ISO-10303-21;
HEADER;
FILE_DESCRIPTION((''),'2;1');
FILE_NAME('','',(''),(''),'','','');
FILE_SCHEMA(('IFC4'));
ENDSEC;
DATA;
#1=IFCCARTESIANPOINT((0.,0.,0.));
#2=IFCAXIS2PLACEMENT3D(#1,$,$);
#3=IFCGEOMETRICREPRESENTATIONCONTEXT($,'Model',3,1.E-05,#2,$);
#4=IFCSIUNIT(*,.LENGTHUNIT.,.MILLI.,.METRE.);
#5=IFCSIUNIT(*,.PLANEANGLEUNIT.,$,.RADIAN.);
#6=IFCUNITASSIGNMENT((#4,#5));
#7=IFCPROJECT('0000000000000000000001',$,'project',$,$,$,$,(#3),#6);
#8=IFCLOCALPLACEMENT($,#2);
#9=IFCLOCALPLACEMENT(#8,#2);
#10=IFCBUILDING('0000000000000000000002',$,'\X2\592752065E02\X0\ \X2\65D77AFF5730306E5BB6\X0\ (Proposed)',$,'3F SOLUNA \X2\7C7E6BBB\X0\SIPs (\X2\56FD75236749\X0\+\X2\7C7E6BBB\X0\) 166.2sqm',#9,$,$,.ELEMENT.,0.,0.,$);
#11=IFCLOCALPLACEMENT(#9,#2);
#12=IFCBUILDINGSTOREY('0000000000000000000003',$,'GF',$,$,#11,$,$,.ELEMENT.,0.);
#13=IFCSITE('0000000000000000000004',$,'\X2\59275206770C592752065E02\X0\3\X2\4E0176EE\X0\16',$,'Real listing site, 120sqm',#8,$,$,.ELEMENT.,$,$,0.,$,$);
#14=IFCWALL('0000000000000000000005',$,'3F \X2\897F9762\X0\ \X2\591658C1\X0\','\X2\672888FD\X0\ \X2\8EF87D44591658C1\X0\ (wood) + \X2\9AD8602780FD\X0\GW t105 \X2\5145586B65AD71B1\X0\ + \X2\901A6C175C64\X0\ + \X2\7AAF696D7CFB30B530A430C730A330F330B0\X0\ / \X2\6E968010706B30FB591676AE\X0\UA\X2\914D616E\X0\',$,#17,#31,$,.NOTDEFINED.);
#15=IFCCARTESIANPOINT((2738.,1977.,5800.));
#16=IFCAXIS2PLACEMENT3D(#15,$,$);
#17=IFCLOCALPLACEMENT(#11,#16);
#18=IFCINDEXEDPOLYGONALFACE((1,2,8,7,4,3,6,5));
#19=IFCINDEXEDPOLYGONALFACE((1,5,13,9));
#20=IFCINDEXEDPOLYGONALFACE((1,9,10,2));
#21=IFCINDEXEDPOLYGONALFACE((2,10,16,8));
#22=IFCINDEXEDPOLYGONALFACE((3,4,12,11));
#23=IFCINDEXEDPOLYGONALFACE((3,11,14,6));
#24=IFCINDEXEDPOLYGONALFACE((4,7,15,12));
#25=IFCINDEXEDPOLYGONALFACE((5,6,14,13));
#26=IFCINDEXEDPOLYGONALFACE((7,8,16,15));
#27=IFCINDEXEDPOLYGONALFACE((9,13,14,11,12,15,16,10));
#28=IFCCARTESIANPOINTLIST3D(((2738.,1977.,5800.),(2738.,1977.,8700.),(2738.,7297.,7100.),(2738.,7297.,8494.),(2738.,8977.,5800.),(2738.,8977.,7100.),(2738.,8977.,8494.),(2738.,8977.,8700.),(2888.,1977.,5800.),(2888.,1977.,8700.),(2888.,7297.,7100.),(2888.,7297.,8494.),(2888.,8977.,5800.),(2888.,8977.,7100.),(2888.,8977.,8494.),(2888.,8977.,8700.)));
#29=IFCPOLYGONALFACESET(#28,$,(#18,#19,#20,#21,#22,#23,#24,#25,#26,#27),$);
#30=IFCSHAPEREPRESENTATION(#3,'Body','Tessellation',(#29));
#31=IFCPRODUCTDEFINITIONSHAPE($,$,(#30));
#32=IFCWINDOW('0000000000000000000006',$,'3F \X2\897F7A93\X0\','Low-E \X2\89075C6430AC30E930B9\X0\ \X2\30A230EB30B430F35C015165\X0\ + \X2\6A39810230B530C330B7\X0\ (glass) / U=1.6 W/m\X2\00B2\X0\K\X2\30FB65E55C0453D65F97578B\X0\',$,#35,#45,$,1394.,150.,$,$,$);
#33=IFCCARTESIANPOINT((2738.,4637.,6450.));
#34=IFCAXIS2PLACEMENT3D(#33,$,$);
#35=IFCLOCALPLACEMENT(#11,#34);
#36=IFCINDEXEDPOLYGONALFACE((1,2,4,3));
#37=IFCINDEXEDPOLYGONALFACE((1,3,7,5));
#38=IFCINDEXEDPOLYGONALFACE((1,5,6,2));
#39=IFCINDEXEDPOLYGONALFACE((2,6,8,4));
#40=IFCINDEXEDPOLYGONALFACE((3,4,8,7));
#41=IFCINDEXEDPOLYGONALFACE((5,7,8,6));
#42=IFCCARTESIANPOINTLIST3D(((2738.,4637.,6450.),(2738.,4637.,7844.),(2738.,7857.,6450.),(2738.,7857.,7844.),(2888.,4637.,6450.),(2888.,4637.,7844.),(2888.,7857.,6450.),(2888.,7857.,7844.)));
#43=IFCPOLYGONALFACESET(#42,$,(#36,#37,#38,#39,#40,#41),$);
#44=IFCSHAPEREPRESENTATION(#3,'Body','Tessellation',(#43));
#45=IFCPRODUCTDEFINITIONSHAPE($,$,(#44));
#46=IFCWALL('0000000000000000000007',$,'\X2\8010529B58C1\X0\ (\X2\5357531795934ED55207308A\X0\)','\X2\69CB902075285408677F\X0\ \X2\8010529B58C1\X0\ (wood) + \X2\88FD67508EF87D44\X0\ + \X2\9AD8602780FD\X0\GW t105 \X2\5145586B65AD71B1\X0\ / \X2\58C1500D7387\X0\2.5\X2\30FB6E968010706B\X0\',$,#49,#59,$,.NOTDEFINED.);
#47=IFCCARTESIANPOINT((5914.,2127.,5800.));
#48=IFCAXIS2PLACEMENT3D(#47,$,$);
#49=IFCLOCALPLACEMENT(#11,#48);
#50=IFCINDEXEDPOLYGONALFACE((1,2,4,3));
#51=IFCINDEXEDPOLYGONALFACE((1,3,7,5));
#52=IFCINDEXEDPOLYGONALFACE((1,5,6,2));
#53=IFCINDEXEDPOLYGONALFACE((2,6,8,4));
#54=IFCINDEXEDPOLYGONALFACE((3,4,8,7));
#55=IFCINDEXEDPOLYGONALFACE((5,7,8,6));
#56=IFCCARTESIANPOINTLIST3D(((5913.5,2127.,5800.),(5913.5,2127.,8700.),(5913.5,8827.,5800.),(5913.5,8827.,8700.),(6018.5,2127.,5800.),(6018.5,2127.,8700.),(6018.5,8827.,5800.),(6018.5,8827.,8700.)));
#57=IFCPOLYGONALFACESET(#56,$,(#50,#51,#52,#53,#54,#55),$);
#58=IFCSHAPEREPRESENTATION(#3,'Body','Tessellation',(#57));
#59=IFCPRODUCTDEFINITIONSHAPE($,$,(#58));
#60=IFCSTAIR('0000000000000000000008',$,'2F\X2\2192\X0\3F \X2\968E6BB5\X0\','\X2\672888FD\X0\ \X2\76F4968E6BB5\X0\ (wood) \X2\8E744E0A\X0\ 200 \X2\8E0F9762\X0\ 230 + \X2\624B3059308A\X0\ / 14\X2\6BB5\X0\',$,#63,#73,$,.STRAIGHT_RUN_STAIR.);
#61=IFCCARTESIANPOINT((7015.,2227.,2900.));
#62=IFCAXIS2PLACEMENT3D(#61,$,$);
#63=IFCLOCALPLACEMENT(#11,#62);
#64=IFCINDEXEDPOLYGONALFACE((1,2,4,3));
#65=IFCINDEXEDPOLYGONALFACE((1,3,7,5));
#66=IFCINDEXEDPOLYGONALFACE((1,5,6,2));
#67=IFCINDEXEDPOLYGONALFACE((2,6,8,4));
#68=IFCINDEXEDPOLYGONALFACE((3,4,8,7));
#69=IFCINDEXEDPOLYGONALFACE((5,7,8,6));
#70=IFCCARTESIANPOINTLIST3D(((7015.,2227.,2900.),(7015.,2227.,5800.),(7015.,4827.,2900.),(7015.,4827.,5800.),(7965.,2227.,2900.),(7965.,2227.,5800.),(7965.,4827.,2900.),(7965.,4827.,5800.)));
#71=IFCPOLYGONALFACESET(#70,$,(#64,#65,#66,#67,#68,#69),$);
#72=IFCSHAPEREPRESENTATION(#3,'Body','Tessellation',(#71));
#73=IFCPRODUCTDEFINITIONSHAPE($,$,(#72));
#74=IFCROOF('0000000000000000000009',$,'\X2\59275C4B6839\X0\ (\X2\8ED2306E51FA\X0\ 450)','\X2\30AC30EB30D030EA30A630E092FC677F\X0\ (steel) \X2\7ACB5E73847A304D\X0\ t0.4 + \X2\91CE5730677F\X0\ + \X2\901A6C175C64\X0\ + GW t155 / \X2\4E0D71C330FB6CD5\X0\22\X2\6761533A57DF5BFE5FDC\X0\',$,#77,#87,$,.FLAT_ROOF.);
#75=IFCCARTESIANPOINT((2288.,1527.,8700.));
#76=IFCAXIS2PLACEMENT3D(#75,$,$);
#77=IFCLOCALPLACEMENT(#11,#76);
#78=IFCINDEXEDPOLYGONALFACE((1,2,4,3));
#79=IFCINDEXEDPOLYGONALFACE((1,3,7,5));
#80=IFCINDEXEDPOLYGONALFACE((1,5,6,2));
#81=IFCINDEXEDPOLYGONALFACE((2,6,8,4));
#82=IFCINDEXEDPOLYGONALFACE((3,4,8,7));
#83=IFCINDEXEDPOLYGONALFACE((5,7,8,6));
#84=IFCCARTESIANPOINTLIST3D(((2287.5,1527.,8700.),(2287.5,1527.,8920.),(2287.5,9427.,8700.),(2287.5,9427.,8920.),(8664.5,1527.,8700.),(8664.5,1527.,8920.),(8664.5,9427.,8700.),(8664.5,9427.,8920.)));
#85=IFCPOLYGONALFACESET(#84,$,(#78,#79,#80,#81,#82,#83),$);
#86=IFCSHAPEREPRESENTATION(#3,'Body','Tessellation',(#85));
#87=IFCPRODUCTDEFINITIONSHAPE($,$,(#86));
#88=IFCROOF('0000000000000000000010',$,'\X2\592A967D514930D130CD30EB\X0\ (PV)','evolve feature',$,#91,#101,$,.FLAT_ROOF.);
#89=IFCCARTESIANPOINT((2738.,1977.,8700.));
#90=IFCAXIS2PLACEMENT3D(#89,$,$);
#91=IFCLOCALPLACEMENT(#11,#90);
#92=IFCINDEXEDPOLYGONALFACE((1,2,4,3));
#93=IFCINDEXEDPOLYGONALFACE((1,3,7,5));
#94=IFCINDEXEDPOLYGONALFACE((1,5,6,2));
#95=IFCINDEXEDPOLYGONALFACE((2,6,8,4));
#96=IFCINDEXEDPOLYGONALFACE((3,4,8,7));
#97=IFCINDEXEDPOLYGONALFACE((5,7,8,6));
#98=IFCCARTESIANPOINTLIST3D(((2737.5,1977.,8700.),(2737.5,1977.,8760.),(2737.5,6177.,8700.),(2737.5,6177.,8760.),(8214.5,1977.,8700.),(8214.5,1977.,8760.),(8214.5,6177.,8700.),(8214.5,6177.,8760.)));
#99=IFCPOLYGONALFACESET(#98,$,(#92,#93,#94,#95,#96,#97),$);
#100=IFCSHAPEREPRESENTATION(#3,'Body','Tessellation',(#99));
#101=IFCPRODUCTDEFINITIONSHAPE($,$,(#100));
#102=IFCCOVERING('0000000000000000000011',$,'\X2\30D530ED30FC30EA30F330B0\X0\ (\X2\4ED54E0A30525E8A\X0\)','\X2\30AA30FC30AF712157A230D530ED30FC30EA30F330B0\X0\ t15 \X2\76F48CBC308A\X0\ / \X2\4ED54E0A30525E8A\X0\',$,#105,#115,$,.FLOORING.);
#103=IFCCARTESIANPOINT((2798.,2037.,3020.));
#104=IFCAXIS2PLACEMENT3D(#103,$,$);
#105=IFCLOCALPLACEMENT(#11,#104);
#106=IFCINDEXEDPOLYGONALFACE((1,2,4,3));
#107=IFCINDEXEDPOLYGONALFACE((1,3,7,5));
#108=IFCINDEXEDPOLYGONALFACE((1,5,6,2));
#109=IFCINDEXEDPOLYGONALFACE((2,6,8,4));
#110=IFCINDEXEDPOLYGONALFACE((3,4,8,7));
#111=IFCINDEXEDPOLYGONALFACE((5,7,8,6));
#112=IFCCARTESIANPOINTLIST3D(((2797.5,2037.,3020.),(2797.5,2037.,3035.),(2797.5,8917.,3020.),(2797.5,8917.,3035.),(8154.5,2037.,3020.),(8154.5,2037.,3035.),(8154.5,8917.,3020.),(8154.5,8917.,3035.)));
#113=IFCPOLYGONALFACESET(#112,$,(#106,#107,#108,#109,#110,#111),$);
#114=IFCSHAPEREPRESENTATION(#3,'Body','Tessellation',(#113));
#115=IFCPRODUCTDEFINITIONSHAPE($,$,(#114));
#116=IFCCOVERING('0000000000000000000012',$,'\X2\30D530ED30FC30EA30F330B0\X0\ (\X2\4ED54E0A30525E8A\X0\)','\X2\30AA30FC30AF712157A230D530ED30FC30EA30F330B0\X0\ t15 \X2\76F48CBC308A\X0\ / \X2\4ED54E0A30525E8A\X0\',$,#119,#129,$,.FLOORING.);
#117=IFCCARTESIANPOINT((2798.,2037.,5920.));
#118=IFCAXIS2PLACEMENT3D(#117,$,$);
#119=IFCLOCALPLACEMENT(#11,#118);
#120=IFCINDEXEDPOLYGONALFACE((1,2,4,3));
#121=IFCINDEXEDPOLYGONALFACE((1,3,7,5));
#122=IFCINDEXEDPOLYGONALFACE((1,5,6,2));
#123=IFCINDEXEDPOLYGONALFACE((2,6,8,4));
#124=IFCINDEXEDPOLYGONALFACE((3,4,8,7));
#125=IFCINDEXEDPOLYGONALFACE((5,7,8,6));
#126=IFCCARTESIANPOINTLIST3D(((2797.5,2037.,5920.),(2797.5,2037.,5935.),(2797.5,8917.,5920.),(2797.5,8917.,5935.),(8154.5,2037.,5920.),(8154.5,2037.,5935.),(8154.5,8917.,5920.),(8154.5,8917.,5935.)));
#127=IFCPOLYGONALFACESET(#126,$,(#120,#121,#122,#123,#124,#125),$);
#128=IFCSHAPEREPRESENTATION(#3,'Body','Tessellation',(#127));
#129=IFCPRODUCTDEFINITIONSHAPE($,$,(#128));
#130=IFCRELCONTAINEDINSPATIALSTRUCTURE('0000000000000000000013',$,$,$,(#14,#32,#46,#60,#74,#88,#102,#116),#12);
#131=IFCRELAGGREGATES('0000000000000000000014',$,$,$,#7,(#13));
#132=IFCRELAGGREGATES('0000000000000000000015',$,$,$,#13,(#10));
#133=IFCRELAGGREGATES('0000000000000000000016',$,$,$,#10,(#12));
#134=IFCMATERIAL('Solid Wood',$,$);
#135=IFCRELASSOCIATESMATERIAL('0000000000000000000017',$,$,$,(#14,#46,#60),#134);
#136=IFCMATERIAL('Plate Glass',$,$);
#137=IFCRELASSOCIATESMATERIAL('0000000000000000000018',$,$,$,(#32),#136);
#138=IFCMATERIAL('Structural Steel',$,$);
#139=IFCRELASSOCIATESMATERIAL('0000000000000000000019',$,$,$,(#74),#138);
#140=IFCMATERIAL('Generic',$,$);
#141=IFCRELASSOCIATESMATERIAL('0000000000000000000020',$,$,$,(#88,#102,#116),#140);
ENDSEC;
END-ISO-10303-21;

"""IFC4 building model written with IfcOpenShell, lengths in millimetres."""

from ifc_helpers import new_model, si_unit, frame, frame_2d, origin, place, context, project, spatial, rectangle, extrude, material, element, fill, save


model = new_model("IFC4")

# Units and contexts
model_context = context("Model", 3, precision=1e-05, world=origin())
ifc_project = project(units=[si_unit("LENGTHUNIT", "METRE", prefix="MILLI"), si_unit("PLANEANGLEUNIT", "RADIAN")], contexts=[model_context])

# Site, building, storey
site_placement = place(None, origin())
site = spatial("IfcSite", under=ifc_project, at=site_placement, Name="大分県大分市3丁目16", ObjectType="Real listing site, 120sqm", CompositionType="ELEMENT", RefElevation=0.0)
building_placement = place(site_placement, origin())
building = spatial("IfcBuilding", under=site, at=building_placement, Name="大分市 旗竿地の家 (Proposed)", ObjectType="3F SOLUNA 籾殻SIPs (国産杉+籾殻) 166.2sqm", CompositionType="ELEMENT", ElevationOfRefHeight=0.0, ElevationOfTerrain=0.0)
storey_placement = place(building_placement, origin())
storey = spatial("IfcBuildingStorey", under=building, at=storey_placement, Name="GF", CompositionType="ELEMENT", Elevation=0.0)

# Shared definitions
ifc_material_1 = material(Name="Solid Wood")

# Shared definitions
ifc_material_2 = material(Name="Plate Glass")

# Shared definitions
ifc_material_3 = material(Name="Generic")

# Wall, opening, window
wall_1_placement = place(storey_placement, frame((2738.0, 1977.0, 5800.0)))
wall_1 = element("IfcWall", 1, at=wall_1_placement, inside=storey, material=ifc_material_1, Name="3F 西面 外壁", Description="木製 軸組外壁 (wood) + 高性能GW t105 充填断熱 + 通気層 + 窯業系サイディング / 準耐火・外皮UA配慮", PredefinedType="NOTDEFINED", context=model_context, shape_type="SweptSolid", body=[
    extrude(rectangle(XDim=150.0, YDim=7000.0, at=frame_2d((75.0, 3500.0))), frame((2738.0, 1977.0, 5800.0)), (0.0, 0.0, 1.0), 2900.0),
])
opening_1_placement = place(storey_placement, frame((2738.0, 4637.0, 6450.0)))
opening_1 = element("IfcOpeningElement", 2, at=opening_1_placement, cuts=wall_1, PredefinedType="NOTDEFINED", context=model_context, shape_type="SweptSolid", body=[
    extrude(rectangle(XDim=150.0, YDim=3220.0, at=frame_2d((75.0, 1610.0))), frame((2738.0, 4637.0, 6450.0)), (0.0, 0.0, 1.0), 1394.0),
])
window_1_placement = place(storey_placement, frame((2738.0, 4637.0, 6450.0)))
window_1 = element("IfcWindow", 3, at=window_1_placement, inside=storey, material=ifc_material_2, Name="3F 西窓", Description="Low-E 複層ガラス アルゴン封入 + 樹脂サッシ (glass) / U=1.6 W/m²K・日射取得型", OverallHeight=1394.0, OverallWidth=150.0, context=model_context, shape_type="SweptSolid", body=[
    extrude(rectangle(XDim=150.0, YDim=3220.0, at=frame_2d((75.0, 1610.0))), frame((2738.0, 4637.0, 6450.0)), (0.0, 0.0, 1.0), 1394.0),
])
fill(opening_1, window_1)

# Wall
wall_2_placement = place(storey_placement, frame((5914.0, 2127.0, 5800.0)))
element("IfcWall", 4, at=wall_2_placement, inside=storey, material=ifc_material_1, Name="耐力壁 (南北間仕切り)", Description="構造用合板 耐力壁 (wood) + 製材軸組 + 高性能GW t105 充填断熱 / 壁倍率2.5・準耐火", PredefinedType="NOTDEFINED", context=model_context, shape_type="SweptSolid", body=[
    extrude(rectangle(XDim=105.0, YDim=6700.0, at=frame_2d((52.0, 3350.0))), frame((5914.0, 2127.0, 5800.0)), (0.0, 0.0, 1.0), 2900.0),
])

# Stair
stair_placement = place(storey_placement, frame((7015.0, 2227.0, 2900.0)))
element("IfcStair", 5, at=stair_placement, inside=storey, material=ifc_material_1, Name="2F→3F 階段", Description="木製 直階段 (wood) 蹴上 200 踏面 230 + 手すり / 14段", PredefinedType="STRAIGHT_RUN_STAIR", context=model_context, shape_type="SweptSolid", body=[
    extrude(rectangle(XDim=950.0, YDim=2600.0, at=frame_2d((475.0, 1300.0))), frame((7015.0, 2227.0, 2900.0)), (0.0, 0.0, 1.0), 2900.0),
])

# Roofs
ifc_material_4 = material(Name="Structural Steel")
roof_1_placement = place(storey_placement, frame((2288.0, 1527.0, 8700.0)))
element("IfcRoof", 6, at=roof_1_placement, inside=storey, material=ifc_material_4, Name="大屋根 (軒の出 450)", Description="ガルバリウム鋼板 (steel) 立平葺き t0.4 + 野地板 + 通気層 + GW t155 / 不燃・法22条区域対応", PredefinedType="FLAT_ROOF", context=model_context, shape_type="SweptSolid", body=[
    extrude(rectangle(XDim=6377.0, YDim=7900.0, at=frame_2d((3188.0, 3950.0))), frame((2288.0, 1527.0, 8700.0)), (0.0, 0.0, 1.0), 220.0),
])
roof_2_placement = place(storey_placement, frame((2738.0, 1977.0, 8700.0)))
element("IfcRoof", 7, at=roof_2_placement, inside=storey, material=ifc_material_3, Name="太陽光パネル (PV)", Description="evolve feature", PredefinedType="FLAT_ROOF", context=model_context, shape_type="SweptSolid", body=[
    extrude(rectangle(XDim=5477.0, YDim=4200.0, at=frame_2d((2738.0, 2100.0))), frame((2738.0, 1977.0, 8700.0)), (0.0, 0.0, 1.0), 60.0),
])

# Coverings
covering_1_placement = place(storey_placement, frame((2798.0, 2037.0, 3020.0)))
element("IfcCovering", 8, at=covering_1_placement, inside=storey, material=ifc_material_3, Name="フローリング (仕上げ床)", Description="オーク無垢フローリング t15 直貼り / 仕上げ床", PredefinedType="FLOORING", context=model_context, shape_type="SweptSolid", body=[
    extrude(rectangle(XDim=5357.0, YDim=6880.0, at=frame_2d((2678.0, 3440.0))), frame((2798.0, 2037.0, 3020.0)), (0.0, 0.0, 1.0), 15.0),
])
covering_2_placement = place(storey_placement, frame((2798.0, 2037.0, 5920.0)))
element("IfcCovering", 9, at=covering_2_placement, inside=storey, material=ifc_material_3, Name="フローリング (仕上げ床)", Description="オーク無垢フローリング t15 直貼り / 仕上げ床", PredefinedType="FLOORING", context=model_context, shape_type="SweptSolid", body=[
    extrude(rectangle(XDim=5357.0, YDim=6880.0, at=frame_2d((2678.0, 3440.0))), frame((2798.0, 2037.0, 5920.0)), (0.0, 0.0, 1.0), 15.0),
])

save(model, "model.ifc")
